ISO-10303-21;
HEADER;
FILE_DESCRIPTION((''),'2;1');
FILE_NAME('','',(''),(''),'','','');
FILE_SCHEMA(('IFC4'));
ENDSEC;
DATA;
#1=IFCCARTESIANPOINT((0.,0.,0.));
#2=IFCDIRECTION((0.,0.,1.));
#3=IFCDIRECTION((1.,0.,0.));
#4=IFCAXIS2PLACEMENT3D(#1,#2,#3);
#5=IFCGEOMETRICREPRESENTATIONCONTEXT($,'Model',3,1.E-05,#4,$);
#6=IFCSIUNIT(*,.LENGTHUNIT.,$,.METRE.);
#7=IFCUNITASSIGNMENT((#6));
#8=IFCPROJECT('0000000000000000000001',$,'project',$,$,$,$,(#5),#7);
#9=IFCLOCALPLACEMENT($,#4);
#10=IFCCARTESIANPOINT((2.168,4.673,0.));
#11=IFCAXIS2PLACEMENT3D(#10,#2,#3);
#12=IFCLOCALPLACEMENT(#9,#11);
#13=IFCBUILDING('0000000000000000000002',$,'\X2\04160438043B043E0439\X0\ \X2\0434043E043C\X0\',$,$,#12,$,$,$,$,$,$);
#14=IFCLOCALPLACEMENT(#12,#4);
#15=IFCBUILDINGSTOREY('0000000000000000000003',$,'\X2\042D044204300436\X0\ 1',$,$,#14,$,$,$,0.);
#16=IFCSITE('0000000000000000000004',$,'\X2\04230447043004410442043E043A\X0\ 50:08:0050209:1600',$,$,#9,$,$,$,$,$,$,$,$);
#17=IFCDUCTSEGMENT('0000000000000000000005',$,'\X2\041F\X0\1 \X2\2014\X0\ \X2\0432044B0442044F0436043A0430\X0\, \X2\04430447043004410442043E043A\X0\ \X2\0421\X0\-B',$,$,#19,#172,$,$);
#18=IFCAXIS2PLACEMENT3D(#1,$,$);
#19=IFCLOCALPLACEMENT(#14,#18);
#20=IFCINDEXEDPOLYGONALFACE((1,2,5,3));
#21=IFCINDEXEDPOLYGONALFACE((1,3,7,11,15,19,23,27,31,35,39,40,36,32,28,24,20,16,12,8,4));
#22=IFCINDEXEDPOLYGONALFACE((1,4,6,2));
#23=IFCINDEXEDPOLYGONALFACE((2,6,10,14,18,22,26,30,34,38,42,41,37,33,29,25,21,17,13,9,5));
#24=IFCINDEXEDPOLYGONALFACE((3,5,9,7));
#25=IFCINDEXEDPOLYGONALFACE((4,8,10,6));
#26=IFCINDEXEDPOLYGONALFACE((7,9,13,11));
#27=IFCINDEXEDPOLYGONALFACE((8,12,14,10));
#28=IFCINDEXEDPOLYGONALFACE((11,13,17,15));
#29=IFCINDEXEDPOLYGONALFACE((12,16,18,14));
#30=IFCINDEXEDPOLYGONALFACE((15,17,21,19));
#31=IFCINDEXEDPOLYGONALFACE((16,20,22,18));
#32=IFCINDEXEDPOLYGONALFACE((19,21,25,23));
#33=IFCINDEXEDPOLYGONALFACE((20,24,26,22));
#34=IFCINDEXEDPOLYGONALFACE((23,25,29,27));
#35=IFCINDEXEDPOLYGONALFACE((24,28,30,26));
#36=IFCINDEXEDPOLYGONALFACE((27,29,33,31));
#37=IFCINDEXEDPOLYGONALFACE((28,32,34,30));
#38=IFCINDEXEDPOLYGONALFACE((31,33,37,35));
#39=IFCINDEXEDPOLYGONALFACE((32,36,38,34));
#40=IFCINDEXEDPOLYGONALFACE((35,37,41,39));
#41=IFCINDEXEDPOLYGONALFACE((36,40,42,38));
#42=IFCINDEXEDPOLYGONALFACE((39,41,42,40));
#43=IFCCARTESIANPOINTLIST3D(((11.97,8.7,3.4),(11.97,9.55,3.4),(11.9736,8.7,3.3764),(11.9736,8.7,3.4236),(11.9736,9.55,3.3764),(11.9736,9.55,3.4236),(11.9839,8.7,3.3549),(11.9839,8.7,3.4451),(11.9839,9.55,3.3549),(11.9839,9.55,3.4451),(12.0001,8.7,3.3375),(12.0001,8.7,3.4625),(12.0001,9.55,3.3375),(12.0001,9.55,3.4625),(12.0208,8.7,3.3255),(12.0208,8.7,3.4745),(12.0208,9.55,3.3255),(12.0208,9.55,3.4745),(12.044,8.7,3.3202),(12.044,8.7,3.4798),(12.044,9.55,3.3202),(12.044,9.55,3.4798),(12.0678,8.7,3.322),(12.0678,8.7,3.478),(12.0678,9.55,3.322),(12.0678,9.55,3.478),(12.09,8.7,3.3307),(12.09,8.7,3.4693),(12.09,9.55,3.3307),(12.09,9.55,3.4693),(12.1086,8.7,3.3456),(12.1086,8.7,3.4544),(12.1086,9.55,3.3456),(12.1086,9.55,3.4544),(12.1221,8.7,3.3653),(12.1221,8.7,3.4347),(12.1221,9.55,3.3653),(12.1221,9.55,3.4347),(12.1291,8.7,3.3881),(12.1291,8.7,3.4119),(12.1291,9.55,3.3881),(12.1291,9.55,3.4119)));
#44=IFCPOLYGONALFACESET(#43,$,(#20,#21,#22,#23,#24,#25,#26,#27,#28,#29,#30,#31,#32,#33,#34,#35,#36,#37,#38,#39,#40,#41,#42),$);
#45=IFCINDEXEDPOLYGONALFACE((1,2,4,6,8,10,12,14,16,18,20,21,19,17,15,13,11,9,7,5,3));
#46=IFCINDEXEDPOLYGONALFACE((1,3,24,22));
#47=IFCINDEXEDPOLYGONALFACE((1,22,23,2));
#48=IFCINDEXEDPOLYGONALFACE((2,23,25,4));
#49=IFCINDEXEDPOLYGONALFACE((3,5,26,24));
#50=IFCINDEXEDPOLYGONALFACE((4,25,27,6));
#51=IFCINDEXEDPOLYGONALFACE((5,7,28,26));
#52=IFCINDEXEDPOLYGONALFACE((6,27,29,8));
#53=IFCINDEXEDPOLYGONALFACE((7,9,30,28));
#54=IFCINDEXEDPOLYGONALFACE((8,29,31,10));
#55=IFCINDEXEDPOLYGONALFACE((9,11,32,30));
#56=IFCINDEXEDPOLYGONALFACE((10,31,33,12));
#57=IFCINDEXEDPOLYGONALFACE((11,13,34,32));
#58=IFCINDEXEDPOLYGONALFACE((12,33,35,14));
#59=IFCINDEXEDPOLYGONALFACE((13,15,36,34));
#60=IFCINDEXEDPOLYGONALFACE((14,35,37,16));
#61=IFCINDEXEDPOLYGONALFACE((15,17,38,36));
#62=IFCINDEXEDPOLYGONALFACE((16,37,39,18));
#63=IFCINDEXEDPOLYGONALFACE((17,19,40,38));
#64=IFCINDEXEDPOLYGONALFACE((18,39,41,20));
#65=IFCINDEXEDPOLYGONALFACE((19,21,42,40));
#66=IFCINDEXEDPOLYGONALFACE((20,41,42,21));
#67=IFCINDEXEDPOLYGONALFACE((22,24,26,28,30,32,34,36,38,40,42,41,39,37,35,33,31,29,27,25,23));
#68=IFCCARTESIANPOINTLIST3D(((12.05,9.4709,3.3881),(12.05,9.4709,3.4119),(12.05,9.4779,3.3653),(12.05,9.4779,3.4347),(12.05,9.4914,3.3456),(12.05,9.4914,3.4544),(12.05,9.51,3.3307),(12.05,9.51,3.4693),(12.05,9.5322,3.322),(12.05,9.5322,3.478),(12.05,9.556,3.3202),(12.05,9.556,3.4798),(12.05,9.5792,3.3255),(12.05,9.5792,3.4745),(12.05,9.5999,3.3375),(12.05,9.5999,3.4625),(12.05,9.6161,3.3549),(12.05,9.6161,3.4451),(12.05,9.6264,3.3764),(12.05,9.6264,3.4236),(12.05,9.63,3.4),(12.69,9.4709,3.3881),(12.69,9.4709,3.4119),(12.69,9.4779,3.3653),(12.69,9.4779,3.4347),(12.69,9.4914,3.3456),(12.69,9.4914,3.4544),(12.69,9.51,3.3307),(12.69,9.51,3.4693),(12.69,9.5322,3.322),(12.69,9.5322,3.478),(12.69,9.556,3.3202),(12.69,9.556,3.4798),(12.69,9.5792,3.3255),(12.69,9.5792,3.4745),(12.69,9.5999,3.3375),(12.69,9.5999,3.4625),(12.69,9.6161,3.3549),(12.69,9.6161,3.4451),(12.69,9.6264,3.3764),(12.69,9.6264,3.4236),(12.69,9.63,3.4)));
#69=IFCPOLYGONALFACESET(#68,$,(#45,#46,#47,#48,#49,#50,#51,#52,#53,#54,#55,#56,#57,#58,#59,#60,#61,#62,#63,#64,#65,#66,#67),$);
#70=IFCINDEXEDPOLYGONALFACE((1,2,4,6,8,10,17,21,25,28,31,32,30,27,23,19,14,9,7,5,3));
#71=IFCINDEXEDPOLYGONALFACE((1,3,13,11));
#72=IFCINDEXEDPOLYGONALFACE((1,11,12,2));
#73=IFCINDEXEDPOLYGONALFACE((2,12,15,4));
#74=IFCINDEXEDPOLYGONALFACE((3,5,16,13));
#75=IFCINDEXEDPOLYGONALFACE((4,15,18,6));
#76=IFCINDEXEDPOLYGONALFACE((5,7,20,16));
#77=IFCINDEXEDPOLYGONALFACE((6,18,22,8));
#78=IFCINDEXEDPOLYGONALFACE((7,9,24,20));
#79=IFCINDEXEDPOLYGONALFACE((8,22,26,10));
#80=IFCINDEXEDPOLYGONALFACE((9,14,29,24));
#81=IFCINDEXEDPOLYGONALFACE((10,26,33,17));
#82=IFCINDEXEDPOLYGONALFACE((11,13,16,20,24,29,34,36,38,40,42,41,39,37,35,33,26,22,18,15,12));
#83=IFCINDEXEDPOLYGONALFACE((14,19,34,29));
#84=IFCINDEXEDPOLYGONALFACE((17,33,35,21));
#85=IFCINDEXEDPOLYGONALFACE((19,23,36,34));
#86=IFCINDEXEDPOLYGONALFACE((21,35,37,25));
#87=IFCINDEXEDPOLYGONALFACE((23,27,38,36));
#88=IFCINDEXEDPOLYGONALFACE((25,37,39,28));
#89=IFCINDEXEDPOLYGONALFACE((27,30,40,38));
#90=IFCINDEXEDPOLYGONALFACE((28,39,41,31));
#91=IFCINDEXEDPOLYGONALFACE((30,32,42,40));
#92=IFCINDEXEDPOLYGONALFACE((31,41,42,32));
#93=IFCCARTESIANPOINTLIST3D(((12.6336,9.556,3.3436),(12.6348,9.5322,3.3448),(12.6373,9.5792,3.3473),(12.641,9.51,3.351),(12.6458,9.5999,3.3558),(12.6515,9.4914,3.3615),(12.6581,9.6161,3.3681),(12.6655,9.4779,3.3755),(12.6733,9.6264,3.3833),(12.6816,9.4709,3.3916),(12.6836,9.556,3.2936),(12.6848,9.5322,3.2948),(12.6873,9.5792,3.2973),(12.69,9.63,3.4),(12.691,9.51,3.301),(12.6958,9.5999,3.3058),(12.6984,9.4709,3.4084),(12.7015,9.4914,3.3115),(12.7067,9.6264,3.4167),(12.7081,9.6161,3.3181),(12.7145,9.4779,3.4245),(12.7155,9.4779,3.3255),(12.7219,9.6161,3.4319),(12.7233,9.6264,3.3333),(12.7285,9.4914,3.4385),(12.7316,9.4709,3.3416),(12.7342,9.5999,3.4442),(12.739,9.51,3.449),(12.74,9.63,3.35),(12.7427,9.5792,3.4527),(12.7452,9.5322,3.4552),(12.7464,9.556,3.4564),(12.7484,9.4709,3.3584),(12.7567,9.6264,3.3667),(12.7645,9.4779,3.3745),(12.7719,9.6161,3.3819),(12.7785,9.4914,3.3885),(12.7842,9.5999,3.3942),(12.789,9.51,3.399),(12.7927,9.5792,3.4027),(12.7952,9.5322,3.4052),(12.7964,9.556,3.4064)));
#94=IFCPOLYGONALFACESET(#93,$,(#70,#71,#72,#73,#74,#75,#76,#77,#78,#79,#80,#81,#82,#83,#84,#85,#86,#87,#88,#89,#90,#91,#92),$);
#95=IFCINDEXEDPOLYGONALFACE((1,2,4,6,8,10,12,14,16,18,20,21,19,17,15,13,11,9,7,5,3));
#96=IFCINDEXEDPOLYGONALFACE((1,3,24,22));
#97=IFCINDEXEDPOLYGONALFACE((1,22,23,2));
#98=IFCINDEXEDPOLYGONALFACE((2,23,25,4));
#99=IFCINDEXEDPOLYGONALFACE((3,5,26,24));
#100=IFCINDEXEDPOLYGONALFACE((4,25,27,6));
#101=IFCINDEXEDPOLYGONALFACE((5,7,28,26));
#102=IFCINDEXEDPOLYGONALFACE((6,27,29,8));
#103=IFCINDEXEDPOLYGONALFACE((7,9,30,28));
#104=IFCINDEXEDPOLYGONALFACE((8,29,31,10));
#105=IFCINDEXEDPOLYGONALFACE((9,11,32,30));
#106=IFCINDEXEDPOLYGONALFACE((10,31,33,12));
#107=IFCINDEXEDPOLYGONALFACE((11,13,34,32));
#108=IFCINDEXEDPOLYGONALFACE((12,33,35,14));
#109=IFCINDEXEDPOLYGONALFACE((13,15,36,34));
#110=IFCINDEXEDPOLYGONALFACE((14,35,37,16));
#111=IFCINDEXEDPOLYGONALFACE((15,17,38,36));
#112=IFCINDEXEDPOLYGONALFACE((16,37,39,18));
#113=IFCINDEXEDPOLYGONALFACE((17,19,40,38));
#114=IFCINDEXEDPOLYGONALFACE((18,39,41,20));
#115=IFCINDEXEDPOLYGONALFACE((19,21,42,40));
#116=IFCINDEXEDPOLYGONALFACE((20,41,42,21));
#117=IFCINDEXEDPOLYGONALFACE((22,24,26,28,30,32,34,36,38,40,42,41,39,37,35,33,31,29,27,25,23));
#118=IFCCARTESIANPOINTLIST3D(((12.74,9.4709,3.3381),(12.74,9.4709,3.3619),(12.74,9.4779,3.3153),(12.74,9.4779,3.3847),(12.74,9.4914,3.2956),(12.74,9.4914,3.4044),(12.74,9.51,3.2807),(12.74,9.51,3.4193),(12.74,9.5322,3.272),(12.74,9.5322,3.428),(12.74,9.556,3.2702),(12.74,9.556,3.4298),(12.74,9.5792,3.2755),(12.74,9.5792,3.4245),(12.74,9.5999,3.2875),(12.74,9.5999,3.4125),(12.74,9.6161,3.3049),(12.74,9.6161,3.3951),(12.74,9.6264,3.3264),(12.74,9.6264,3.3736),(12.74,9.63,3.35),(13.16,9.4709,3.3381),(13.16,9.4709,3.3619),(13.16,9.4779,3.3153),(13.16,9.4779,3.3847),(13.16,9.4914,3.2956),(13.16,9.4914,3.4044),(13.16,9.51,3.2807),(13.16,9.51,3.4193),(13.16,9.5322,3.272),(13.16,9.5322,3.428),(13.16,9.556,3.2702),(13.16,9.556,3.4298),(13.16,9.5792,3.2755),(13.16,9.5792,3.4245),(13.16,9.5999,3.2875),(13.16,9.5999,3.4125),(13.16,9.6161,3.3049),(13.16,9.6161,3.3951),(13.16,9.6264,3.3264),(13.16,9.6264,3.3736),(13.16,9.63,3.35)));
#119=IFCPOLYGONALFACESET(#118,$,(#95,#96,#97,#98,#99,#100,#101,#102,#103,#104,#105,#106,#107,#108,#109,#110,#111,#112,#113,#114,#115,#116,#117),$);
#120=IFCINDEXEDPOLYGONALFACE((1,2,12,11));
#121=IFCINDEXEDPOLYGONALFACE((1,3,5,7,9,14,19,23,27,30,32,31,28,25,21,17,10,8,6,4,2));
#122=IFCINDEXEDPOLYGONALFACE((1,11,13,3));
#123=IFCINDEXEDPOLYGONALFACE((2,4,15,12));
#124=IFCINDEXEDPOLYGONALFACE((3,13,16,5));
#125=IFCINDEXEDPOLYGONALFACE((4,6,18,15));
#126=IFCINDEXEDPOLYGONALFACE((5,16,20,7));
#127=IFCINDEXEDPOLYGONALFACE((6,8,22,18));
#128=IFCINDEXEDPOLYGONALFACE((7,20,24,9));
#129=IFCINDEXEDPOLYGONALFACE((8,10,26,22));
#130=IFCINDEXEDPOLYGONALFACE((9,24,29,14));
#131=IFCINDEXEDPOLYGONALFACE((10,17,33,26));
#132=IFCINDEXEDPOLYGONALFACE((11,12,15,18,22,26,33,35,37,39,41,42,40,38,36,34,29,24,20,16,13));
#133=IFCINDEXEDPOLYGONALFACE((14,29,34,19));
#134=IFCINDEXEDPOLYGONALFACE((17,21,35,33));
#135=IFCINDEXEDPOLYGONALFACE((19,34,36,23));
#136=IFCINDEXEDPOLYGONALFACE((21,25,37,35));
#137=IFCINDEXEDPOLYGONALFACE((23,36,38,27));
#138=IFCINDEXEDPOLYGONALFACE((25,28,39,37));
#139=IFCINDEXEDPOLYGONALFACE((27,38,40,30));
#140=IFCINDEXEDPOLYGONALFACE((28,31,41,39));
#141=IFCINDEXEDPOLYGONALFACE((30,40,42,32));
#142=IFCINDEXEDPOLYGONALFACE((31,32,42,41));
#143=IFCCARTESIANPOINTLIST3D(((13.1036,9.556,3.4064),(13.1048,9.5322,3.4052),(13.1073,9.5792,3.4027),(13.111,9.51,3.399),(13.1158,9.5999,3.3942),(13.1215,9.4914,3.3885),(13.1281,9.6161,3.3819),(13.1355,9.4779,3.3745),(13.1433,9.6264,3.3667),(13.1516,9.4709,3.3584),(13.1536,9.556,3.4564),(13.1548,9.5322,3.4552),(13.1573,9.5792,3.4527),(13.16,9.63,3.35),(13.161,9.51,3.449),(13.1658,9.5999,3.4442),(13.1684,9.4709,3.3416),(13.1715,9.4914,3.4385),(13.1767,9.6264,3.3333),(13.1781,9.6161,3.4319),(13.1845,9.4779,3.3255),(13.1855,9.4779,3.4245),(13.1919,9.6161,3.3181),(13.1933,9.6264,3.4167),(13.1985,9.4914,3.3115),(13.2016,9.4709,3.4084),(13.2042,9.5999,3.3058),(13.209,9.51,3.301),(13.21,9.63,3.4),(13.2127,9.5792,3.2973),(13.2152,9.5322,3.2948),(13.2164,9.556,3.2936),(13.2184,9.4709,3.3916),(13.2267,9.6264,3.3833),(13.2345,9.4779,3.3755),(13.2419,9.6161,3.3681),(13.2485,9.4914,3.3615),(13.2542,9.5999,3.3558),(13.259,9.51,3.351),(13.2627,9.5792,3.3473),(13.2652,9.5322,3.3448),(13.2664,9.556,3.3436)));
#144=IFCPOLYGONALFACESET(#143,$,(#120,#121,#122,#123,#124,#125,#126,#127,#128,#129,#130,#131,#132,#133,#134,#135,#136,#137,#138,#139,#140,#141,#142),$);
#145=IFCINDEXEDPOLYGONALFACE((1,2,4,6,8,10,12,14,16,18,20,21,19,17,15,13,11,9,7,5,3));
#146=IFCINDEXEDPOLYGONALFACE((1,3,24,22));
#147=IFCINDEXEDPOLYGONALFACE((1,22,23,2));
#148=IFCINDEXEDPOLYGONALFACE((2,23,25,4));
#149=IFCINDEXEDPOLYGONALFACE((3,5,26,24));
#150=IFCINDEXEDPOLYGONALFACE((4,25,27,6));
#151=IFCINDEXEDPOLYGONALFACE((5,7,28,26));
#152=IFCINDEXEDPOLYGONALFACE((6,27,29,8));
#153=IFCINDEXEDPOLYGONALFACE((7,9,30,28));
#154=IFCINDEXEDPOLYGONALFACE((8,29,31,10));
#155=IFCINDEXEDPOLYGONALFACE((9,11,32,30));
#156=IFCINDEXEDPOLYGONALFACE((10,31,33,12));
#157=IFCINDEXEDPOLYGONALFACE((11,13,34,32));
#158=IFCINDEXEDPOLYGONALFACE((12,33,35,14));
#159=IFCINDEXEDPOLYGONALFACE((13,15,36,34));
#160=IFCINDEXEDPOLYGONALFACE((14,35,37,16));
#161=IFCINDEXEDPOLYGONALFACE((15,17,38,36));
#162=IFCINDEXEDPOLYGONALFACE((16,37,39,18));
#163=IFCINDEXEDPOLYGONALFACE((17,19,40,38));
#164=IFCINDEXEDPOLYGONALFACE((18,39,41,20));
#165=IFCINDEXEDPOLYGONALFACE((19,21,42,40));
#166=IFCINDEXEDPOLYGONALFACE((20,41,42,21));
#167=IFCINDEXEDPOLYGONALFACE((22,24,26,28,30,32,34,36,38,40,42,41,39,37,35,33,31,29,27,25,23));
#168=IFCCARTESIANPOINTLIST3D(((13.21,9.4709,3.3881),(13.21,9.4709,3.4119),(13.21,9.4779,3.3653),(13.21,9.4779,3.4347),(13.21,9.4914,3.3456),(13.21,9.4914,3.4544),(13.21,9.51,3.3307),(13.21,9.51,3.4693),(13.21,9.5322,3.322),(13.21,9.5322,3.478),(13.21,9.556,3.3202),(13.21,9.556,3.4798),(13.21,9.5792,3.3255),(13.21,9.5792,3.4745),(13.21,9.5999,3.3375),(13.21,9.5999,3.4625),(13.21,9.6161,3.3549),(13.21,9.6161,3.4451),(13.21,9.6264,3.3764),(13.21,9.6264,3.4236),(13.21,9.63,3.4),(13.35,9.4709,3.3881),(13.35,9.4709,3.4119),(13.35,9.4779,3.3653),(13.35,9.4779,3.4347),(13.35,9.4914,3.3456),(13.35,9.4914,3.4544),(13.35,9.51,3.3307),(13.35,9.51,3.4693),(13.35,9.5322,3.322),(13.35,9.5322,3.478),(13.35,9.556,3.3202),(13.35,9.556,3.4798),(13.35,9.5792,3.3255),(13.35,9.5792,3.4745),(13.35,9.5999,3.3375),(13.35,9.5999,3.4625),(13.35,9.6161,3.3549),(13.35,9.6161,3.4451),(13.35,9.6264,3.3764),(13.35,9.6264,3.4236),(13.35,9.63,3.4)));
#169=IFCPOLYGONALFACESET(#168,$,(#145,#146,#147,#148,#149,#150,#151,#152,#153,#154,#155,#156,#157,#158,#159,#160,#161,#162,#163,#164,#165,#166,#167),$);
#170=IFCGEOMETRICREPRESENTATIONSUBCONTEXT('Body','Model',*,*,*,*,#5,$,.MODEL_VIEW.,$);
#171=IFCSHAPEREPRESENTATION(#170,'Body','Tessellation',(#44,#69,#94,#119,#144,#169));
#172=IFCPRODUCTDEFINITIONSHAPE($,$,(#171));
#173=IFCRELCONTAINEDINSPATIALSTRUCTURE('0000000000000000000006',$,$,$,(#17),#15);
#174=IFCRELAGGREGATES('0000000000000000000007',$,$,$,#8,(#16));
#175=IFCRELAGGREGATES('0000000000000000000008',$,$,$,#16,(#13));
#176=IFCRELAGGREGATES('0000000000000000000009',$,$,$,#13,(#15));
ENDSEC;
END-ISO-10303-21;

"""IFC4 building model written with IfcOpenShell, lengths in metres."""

from ifc_helpers import new_model, si_unit, frame, origin_with_axes, origin_2d, place, context, subcontext, project, spatial, circle, extrude, element, save


model = new_model("IFC4")

# Units and contexts
model_context = context("Model", 3, precision=1e-05, world=origin_with_axes())
body_context = subcontext(model_context, "Body", "Model", "MODEL_VIEW")
ifc_project = project(units=[si_unit("LENGTHUNIT", "METRE")], contexts=[model_context])

# Site, building, storey
site_placement = place(None, origin_with_axes())
site = spatial("IfcSite", under=ifc_project, at=site_placement, Name="Участок 50:08:0050209:1600")
building_placement = place(site_placement, frame((2.168, 4.673, 0.0), z_axis=(0.0, 0.0, 1.0), x_axis=(1.0, 0.0, 0.0)))
building = spatial("IfcBuilding", under=site, at=building_placement, Name="Жилой дом")
storey_placement = place(building_placement, origin_with_axes())
storey = spatial("IfcBuildingStorey", under=building, at=storey_placement, Name="Этаж 1", Elevation=0.0)

# Duct segment
duct_segment_1_placement = place(storey_placement, origin_with_axes())
element("IfcDuctSegment", 1, at=duct_segment_1_placement, inside=storey, Name="П1 — вытяжка, участок С-B", context=body_context, shape_type="SweptSolid", body=[
    extrude(circle(Radius=0.08, at=origin_2d()), frame((12.05, 8.7, 3.4), z_axis=(0.0, 1.0, 0.0), x_axis=(-1.0, 0.0, 0.0)), (0.0, 0.0, 1.0), 0.85),
    extrude(circle(Radius=0.08, at=origin_2d()), frame((12.05, 9.55, 3.4), z_axis=(1.0, 0.0, 0.0), x_axis=(0.0, 1.0, 0.0)), (0.0, 0.0, 1.0), 0.64),
    extrude(circle(Radius=0.08, at=origin_2d()), frame((12.69, 9.55, 3.4), z_axis=(0.707107, 0.0, -0.707107), x_axis=(0.0, 1.0, 0.0)), (0.0, 0.0, 1.0), 0.0707),
    extrude(circle(Radius=0.08, at=origin_2d()), frame((12.74, 9.55, 3.35), z_axis=(1.0, 0.0, 0.0), x_axis=(0.0, 1.0, 0.0)), (0.0, 0.0, 1.0), 0.42),
    extrude(circle(Radius=0.08, at=origin_2d()), frame((13.16, 9.55, 3.35), z_axis=(0.707107, 0.0, 0.707107), x_axis=(0.0, 1.0, 0.0)), (0.0, 0.0, 1.0), 0.0707),
    extrude(circle(Radius=0.08, at=origin_2d()), frame((13.21, 9.55, 3.4), z_axis=(1.0, 0.0, 0.0), x_axis=(0.0, 1.0, 0.0)), (0.0, 0.0, 1.0), 0.14),
])

save(model, "model.ifc")
